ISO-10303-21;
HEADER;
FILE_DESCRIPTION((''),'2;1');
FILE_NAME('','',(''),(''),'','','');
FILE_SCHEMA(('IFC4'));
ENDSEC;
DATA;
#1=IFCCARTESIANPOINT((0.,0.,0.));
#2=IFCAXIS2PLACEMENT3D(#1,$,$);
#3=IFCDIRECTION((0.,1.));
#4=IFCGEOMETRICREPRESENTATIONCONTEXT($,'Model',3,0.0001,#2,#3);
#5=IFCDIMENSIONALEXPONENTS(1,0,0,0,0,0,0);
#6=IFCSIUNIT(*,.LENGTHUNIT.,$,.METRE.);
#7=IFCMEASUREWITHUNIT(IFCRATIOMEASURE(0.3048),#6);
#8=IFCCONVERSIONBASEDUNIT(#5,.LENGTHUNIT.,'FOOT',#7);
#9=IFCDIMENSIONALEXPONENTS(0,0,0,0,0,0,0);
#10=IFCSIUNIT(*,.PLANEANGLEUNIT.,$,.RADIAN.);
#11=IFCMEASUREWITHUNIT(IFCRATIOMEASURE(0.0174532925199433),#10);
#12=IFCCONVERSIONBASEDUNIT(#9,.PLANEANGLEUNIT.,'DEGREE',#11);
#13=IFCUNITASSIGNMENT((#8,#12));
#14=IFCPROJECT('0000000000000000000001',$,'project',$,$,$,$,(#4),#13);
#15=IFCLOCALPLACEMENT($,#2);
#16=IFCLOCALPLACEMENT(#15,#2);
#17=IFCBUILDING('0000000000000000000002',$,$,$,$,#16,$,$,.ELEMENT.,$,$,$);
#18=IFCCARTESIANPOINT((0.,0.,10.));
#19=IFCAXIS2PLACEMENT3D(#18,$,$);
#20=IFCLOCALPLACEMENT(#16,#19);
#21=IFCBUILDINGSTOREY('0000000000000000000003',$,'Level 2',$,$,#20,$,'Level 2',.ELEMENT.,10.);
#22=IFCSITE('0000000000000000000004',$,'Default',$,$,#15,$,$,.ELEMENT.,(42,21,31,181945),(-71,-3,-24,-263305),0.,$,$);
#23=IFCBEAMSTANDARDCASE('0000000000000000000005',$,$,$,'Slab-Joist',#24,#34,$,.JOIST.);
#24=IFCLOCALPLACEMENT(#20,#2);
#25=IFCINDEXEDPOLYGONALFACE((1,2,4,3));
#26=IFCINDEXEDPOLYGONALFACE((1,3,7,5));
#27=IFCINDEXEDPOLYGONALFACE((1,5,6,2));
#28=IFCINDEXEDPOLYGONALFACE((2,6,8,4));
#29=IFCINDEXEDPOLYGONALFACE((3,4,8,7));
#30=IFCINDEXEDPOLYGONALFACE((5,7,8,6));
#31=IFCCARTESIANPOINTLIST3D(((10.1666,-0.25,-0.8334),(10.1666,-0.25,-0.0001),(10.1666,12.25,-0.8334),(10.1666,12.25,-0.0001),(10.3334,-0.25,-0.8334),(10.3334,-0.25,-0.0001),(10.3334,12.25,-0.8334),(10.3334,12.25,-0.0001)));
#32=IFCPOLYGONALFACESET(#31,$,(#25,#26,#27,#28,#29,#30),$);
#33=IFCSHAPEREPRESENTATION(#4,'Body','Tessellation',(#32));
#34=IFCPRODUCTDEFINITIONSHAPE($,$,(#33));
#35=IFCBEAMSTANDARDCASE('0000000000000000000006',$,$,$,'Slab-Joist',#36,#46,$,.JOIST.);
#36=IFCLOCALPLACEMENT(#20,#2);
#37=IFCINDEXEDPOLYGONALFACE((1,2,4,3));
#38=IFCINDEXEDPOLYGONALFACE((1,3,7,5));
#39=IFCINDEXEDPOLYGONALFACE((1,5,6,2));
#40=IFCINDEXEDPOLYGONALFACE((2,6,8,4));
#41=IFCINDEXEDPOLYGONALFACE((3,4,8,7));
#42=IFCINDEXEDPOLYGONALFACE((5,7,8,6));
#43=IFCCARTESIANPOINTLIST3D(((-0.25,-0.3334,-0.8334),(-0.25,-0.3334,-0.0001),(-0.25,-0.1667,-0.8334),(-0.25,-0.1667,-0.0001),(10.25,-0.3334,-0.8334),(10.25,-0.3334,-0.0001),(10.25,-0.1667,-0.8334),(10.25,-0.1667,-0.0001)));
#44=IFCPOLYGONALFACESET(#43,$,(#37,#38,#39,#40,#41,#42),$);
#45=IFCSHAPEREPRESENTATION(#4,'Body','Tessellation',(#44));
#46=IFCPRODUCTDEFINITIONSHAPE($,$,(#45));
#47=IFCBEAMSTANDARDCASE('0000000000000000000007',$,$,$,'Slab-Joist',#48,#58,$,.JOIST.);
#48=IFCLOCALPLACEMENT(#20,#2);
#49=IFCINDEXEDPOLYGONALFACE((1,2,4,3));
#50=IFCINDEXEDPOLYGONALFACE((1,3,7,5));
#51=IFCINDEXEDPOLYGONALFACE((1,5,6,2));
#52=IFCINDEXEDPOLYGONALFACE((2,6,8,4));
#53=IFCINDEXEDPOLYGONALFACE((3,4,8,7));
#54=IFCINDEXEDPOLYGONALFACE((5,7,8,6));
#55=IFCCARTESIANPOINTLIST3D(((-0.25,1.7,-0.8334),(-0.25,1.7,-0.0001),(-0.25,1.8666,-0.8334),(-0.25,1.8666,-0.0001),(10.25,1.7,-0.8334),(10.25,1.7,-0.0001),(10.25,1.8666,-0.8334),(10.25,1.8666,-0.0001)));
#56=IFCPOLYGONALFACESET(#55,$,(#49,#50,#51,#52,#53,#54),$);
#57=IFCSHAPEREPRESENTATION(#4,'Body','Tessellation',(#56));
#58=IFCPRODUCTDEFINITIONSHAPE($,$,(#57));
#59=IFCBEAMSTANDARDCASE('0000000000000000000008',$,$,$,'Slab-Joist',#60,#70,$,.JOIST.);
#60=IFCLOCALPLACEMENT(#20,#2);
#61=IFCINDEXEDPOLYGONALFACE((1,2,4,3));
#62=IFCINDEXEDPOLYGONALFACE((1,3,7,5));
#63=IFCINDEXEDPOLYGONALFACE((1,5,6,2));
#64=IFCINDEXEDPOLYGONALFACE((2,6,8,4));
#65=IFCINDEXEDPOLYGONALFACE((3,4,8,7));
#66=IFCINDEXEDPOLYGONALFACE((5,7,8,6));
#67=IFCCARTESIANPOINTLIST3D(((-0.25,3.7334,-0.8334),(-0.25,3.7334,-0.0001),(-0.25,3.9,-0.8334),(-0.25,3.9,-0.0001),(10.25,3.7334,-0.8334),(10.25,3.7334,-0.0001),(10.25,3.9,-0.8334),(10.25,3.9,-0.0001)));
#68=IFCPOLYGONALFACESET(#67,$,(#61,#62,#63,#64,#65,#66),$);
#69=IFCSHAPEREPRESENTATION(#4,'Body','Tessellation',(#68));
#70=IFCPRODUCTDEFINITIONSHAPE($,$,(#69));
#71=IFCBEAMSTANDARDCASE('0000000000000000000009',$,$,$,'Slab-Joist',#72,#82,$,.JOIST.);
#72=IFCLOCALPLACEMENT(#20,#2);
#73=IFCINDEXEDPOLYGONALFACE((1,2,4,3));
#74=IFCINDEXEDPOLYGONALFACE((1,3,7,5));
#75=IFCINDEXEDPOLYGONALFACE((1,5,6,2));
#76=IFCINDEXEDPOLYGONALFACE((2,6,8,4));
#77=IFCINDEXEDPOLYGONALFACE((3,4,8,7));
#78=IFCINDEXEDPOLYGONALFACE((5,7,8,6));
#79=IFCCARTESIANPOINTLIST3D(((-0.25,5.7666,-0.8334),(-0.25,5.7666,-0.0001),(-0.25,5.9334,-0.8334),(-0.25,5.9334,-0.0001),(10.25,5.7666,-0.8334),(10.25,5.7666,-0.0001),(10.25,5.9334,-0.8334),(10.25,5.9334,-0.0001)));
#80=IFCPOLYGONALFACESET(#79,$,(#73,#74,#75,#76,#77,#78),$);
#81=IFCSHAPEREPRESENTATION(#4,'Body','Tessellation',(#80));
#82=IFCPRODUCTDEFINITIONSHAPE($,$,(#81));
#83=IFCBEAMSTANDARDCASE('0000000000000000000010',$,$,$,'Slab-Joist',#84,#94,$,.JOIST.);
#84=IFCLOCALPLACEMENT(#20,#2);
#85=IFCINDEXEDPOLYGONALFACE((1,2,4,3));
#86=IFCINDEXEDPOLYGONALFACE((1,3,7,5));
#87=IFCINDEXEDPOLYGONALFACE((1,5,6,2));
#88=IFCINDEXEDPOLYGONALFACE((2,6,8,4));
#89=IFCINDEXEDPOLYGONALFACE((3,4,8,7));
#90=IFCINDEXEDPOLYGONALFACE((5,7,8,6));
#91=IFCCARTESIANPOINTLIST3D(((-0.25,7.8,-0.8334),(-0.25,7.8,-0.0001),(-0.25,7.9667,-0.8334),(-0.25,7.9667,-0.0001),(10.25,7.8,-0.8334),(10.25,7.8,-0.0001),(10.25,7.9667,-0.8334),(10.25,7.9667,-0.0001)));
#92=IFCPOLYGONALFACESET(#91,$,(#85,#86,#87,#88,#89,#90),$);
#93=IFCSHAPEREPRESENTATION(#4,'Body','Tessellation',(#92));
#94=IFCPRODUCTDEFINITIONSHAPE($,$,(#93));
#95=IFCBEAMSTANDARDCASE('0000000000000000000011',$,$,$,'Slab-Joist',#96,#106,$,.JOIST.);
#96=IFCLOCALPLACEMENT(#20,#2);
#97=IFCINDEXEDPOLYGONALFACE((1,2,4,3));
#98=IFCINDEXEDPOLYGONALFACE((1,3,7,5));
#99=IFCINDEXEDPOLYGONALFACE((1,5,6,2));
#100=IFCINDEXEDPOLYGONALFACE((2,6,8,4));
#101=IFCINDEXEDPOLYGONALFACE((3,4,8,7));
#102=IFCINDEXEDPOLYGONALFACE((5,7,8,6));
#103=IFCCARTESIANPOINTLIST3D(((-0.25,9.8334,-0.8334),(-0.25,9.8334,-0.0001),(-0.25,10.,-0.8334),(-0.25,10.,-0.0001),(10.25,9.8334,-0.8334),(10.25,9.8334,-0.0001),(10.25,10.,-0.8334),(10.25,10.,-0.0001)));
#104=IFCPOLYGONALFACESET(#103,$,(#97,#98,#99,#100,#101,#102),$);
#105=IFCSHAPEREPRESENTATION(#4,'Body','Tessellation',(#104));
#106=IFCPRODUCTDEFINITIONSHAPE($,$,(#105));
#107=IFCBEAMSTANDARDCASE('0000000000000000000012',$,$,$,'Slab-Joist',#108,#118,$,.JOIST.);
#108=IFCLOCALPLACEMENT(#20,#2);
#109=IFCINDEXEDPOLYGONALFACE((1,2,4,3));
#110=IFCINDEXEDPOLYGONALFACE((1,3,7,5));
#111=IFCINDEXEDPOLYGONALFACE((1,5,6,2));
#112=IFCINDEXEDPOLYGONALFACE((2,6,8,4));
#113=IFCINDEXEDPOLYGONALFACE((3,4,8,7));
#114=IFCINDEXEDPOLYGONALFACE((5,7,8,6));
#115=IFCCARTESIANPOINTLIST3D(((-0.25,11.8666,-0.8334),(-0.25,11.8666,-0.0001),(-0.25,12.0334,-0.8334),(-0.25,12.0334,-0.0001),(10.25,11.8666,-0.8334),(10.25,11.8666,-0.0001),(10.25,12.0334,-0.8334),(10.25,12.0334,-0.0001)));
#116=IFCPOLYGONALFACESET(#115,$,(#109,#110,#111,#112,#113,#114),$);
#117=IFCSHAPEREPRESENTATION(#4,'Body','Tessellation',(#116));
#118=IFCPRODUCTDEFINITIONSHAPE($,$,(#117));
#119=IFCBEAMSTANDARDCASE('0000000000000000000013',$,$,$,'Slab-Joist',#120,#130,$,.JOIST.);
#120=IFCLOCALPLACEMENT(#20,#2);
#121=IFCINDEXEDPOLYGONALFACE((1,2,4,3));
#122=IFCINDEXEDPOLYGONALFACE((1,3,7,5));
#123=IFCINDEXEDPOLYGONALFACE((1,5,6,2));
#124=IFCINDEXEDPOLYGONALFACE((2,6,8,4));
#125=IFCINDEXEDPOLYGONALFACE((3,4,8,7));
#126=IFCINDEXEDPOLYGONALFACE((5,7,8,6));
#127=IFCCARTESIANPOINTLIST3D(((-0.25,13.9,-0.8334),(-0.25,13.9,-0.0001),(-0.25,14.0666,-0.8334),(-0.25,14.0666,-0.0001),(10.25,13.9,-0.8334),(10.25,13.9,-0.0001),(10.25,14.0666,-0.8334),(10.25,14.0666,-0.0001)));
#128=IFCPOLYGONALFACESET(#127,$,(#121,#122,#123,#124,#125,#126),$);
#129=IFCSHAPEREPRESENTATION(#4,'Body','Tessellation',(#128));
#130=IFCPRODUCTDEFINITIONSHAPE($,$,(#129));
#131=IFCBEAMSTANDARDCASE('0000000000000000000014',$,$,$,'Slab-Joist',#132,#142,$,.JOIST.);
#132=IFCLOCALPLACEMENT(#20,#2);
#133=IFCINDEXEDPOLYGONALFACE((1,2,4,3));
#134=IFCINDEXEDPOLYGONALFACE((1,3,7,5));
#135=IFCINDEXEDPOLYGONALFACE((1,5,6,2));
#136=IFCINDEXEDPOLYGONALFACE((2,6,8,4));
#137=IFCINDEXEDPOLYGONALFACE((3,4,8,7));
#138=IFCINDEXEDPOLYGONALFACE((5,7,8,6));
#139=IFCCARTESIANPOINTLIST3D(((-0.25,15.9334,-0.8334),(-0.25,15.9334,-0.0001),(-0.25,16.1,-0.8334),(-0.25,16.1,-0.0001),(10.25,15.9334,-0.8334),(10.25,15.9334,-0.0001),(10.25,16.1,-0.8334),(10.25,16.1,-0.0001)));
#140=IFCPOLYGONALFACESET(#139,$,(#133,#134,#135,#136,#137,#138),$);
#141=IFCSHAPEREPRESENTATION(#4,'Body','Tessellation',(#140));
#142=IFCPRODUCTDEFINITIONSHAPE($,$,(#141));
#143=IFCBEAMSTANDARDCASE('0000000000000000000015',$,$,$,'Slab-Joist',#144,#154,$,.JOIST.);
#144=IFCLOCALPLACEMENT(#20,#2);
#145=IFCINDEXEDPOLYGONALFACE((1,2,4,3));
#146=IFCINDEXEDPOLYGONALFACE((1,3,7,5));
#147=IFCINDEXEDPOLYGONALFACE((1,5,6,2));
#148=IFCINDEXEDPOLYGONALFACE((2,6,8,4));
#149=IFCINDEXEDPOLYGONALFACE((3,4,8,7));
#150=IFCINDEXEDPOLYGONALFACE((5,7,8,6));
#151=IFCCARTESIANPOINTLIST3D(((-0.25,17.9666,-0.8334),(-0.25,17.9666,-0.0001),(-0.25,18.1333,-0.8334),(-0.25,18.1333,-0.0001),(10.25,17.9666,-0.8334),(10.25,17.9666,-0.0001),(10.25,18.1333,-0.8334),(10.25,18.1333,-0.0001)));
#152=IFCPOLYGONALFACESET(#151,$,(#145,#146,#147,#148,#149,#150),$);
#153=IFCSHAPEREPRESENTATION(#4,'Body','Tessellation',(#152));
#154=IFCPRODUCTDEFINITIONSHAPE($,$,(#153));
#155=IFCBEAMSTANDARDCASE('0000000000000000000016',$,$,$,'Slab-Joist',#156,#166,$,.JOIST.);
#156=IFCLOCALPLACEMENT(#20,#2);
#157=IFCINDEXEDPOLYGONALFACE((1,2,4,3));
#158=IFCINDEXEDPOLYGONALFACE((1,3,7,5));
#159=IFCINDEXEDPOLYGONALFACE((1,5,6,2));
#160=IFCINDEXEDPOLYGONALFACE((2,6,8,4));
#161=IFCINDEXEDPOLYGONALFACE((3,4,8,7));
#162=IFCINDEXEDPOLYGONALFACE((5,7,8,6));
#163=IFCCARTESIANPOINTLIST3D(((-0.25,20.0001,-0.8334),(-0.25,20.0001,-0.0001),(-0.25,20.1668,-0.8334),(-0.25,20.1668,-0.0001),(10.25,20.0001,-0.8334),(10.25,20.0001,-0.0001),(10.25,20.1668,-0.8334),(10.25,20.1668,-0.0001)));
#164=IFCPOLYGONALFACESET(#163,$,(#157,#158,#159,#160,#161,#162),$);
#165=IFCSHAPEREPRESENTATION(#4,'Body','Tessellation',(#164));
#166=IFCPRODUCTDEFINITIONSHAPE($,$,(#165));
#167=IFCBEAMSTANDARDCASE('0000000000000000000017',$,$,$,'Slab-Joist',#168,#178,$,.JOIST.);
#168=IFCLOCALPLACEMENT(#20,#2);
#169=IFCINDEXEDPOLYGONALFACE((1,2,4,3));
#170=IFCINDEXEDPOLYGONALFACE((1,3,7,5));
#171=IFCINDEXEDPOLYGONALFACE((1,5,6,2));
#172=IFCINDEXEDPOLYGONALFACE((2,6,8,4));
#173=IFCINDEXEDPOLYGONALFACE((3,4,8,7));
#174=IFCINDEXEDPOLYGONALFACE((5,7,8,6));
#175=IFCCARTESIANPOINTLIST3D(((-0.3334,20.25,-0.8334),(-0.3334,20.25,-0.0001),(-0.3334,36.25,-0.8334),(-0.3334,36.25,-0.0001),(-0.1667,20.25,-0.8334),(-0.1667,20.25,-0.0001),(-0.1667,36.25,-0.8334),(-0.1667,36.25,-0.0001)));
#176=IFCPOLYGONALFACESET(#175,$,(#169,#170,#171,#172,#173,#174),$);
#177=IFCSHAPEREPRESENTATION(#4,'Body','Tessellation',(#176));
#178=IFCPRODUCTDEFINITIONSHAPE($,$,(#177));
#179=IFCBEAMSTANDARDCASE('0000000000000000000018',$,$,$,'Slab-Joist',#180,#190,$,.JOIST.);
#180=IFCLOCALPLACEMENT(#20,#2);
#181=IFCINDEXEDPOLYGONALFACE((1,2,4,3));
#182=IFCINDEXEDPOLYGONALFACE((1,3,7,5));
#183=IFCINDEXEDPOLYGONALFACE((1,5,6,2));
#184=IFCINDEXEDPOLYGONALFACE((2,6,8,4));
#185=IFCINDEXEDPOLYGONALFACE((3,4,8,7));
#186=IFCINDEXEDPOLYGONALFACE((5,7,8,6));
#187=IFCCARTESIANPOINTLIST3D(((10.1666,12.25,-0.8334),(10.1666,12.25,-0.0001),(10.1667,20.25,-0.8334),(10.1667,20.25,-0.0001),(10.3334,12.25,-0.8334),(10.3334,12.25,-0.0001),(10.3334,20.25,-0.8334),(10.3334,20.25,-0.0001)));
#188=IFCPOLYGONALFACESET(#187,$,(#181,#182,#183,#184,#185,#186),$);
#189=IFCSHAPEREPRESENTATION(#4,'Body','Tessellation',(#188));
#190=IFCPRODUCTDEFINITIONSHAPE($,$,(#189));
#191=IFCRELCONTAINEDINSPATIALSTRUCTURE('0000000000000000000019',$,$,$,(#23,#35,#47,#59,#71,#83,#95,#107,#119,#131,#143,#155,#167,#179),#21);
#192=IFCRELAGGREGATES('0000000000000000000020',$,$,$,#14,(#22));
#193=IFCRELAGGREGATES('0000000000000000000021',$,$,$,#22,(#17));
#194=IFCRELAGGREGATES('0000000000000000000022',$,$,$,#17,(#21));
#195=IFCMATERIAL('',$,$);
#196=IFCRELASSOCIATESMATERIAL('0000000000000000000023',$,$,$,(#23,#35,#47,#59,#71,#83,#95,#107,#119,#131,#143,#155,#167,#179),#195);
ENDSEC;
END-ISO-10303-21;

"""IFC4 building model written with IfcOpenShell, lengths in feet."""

from ifc_helpers import new_model, entity, si_unit, converted_unit, direction, frame, origin, origin_with_axes, place, context, project, spatial, rectangle, extrude, material, element, save


model = new_model("IFC4")

# Units and contexts
model_context = context("Model", 3, precision=0.0001, world=origin(), true_north=direction((0.0, 1.0)))
ifc_project = project(units=[converted_unit("LENGTHUNIT", "FOOT", entity("IfcRatioMeasure", 0.3048), si_unit("LENGTHUNIT", "METRE"), dimensions=[1, 0, 0, 0, 0, 0, 0]), converted_unit("PLANEANGLEUNIT", "DEGREE", entity("IfcRatioMeasure", 0.0174532925199433), si_unit("PLANEANGLEUNIT", "RADIAN"), dimensions=[0, 0, 0, 0, 0, 0, 0])], contexts=[model_context])

# Site, building, storey
site_placement = place(None, origin())
site = spatial("IfcSite", under=ifc_project, at=site_placement, Name="Default", CompositionType="ELEMENT", RefLatitude=(42, 21, 31, 181945), RefLongitude=(-71, -3, -24, -263305), RefElevation=0.0)
building_placement = place(site_placement, origin())
building = spatial("IfcBuilding", under=site, at=building_placement, CompositionType="ELEMENT")
storey_placement = place(building_placement, frame((0.0, 0.0, 10.0)))
storey = spatial("IfcBuildingStorey", under=building, at=storey_placement, Name="Level 2", LongName="Level 2", CompositionType="ELEMENT", Elevation=10.0)

# Beams
ifc_material = material(Name="")
placement_1 = place(storey_placement, frame((10.25, -0.25, 0.0), z_axis=(0.0, 0.0, 1.0), x_axis=(1.0, 0.0, 0.0)))
beam_1_placement = place(placement_1, frame((0.0, 0.0, -0.4167), z_axis=(0.0, 1.0, 0.0), x_axis=(-1.0, 0.0, 0.0)))
element("IfcBeamStandardCase", 1, at=beam_1_placement, inside=storey, material=ifc_material, ObjectType="Slab-Joist", PredefinedType="JOIST", context=model_context, shape_type="SweptSolid", body=[
    extrude(rectangle(XDim=0.1667, YDim=0.8333), origin_with_axes(), (0.0, 0.0, 1.0), 12.5),
])
placement_2 = place(storey_placement, frame((-0.25, -0.25, 0.0), z_axis=(0.0, 0.0, 1.0), x_axis=(1.0, 0.0, 0.0)))
beam_2_placement = place(placement_2, frame((0.0, 0.0, -0.4167), z_axis=(1.0, 0.0, 0.0), x_axis=(0.0, 1.0, 0.0)))
element("IfcBeamStandardCase", 2, at=beam_2_placement, inside=storey, material=ifc_material, ObjectType="Slab-Joist", PredefinedType="JOIST", context=model_context, shape_type="SweptSolid", body=[
    extrude(rectangle(XDim=0.1667, YDim=0.8333), origin_with_axes(), (0.0, 0.0, 1.0), 10.5),
])
placement_3 = place(storey_placement, frame((-0.25, -0.25, 0.0), z_axis=(0.0, 0.0, 1.0), x_axis=(1.0, 0.0, 0.0)))
beam_3_placement = place(placement_3, frame((0.0, 2.0333, -0.4167), z_axis=(1.0, 0.0, 0.0), x_axis=(0.0, 1.0, 0.0)))
element("IfcBeamStandardCase", 3, at=beam_3_placement, inside=storey, material=ifc_material, ObjectType="Slab-Joist", PredefinedType="JOIST", context=model_context, shape_type="SweptSolid", body=[
    extrude(rectangle(XDim=0.1667, YDim=0.8333), origin_with_axes(), (0.0, 0.0, 1.0), 10.5),
])
placement_4 = place(storey_placement, frame((-0.25, -0.25, 0.0), z_axis=(0.0, 0.0, 1.0), x_axis=(1.0, 0.0, 0.0)))
beam_4_placement = place(placement_4, frame((0.0, 4.0667, -0.4167), z_axis=(1.0, 0.0, 0.0), x_axis=(0.0, 1.0, 0.0)))
element("IfcBeamStandardCase", 4, at=beam_4_placement, inside=storey, material=ifc_material, ObjectType="Slab-Joist", PredefinedType="JOIST", context=model_context, shape_type="SweptSolid", body=[
    extrude(rectangle(XDim=0.1667, YDim=0.8333), origin_with_axes(), (0.0, 0.0, 1.0), 10.5),
])
placement_5 = place(storey_placement, frame((-0.25, -0.25, 0.0), z_axis=(0.0, 0.0, 1.0), x_axis=(1.0, 0.0, 0.0)))
beam_5_placement = place(placement_5, frame((0.0, 6.1, -0.4167), z_axis=(1.0, 0.0, 0.0), x_axis=(0.0, 1.0, 0.0)))
element("IfcBeamStandardCase", 5, at=beam_5_placement, inside=storey, material=ifc_material, ObjectType="Slab-Joist", PredefinedType="JOIST", context=model_context, shape_type="SweptSolid", body=[
    extrude(rectangle(XDim=0.1667, YDim=0.8333), origin_with_axes(), (0.0, 0.0, 1.0), 10.5),
])
placement_6 = place(storey_placement, frame((-0.25, -0.25, 0.0), z_axis=(0.0, 0.0, 1.0), x_axis=(1.0, 0.0, 0.0)))
beam_6_placement = place(placement_6, frame((0.0, 8.1333, -0.4167), z_axis=(1.0, 0.0, 0.0), x_axis=(0.0, 1.0, 0.0)))
element("IfcBeamStandardCase", 6, at=beam_6_placement, inside=storey, material=ifc_material, ObjectType="Slab-Joist", PredefinedType="JOIST", context=model_context, shape_type="SweptSolid", body=[
    extrude(rectangle(XDim=0.1667, YDim=0.8333), origin_with_axes(), (0.0, 0.0, 1.0), 10.5),
])
placement_7 = place(storey_placement, frame((-0.25, -0.25, 0.0), z_axis=(0.0, 0.0, 1.0), x_axis=(1.0, 0.0, 0.0)))
beam_7_placement = place(placement_7, frame((0.0, 10.1667, -0.4167), z_axis=(1.0, 0.0, 0.0), x_axis=(0.0, 1.0, 0.0)))
element("IfcBeamStandardCase", 7, at=beam_7_placement, inside=storey, material=ifc_material, ObjectType="Slab-Joist", PredefinedType="JOIST", context=model_context, shape_type="SweptSolid", body=[
    extrude(rectangle(XDim=0.1667, YDim=0.8333), origin_with_axes(), (0.0, 0.0, 1.0), 10.5),
])
placement_8 = place(storey_placement, frame((-0.25, -0.25, 0.0), z_axis=(0.0, 0.0, 1.0), x_axis=(1.0, 0.0, 0.0)))
beam_8_placement = place(placement_8, frame((0.0, 12.2, -0.4167), z_axis=(1.0, 0.0, 0.0), x_axis=(0.0, 1.0, 0.0)))
element("IfcBeamStandardCase", 8, at=beam_8_placement, inside=storey, material=ifc_material, ObjectType="Slab-Joist", PredefinedType="JOIST", context=model_context, shape_type="SweptSolid", body=[
    extrude(rectangle(XDim=0.1667, YDim=0.8333), origin_with_axes(), (0.0, 0.0, 1.0), 10.5),
])
placement_9 = place(storey_placement, frame((-0.25, -0.25, 0.0), z_axis=(0.0, 0.0, 1.0), x_axis=(1.0, 0.0, 0.0)))
beam_9_placement = place(placement_9, frame((0.0, 14.2333, -0.4167), z_axis=(1.0, 0.0, 0.0), x_axis=(0.0, 1.0, 0.0)))
element("IfcBeamStandardCase", 9, at=beam_9_placement, inside=storey, material=ifc_material, ObjectType="Slab-Joist", PredefinedType="JOIST", context=model_context, shape_type="SweptSolid", body=[
    extrude(rectangle(XDim=0.1667, YDim=0.8333), origin_with_axes(), (0.0, 0.0, 1.0), 10.5),
])
placement_10 = place(storey_placement, frame((-0.25, -0.25, 0.0), z_axis=(0.0, 0.0, 1.0), x_axis=(1.0, 0.0, 0.0)))
beam_10_placement = place(placement_10, frame((0.0, 16.2667, -0.4167), z_axis=(1.0, 0.0, 0.0), x_axis=(0.0, 1.0, 0.0)))
element("IfcBeamStandardCase", 10, at=beam_10_placement, inside=storey, material=ifc_material, ObjectType="Slab-Joist", PredefinedType="JOIST", context=model_context, shape_type="SweptSolid", body=[
    extrude(rectangle(XDim=0.1667, YDim=0.8333), origin_with_axes(), (0.0, 0.0, 1.0), 10.5),
])
placement_11 = place(storey_placement, frame((-0.25, -0.25, 0.0), z_axis=(0.0, 0.0, 1.0), x_axis=(1.0, 0.0, 0.0)))
beam_11_placement = place(placement_11, frame((0.0, 18.3, -0.4167), z_axis=(1.0, 0.0, 0.0), x_axis=(0.0, 1.0, 0.0)))
element("IfcBeamStandardCase", 11, at=beam_11_placement, inside=storey, material=ifc_material, ObjectType="Slab-Joist", PredefinedType="JOIST", context=model_context, shape_type="SweptSolid", body=[
    extrude(rectangle(XDim=0.1667, YDim=0.8333), origin_with_axes(), (0.0, 0.0, 1.0), 10.5),
])
placement_12 = place(storey_placement, frame((-0.25, -0.25, 0.0), z_axis=(0.0, 0.0, 1.0), x_axis=(1.0, 0.0, 0.0)))
beam_12_placement = place(placement_12, frame((0.0, 20.3334, -0.4167), z_axis=(1.0, 0.0, 0.0), x_axis=(0.0, 1.0, 0.0)))
element("IfcBeamStandardCase", 12, at=beam_12_placement, inside=storey, material=ifc_material, ObjectType="Slab-Joist", PredefinedType="JOIST", context=model_context, shape_type="SweptSolid", body=[
    extrude(rectangle(XDim=0.1667, YDim=0.8333), origin_with_axes(), (0.0, 0.0, 1.0), 10.5),
])
placement_13 = place(storey_placement, frame((-0.25, 20.25, 0.0), z_axis=(0.0, 0.0, 1.0), x_axis=(1.0, 0.0, 0.0)))
beam_13_placement = place(placement_13, frame((0.0, 0.0, -0.4167), z_axis=(0.0, 1.0, 0.0), x_axis=(-1.0, 0.0, 0.0)))
element("IfcBeamStandardCase", 13, at=beam_13_placement, inside=storey, material=ifc_material, ObjectType="Slab-Joist", PredefinedType="JOIST", context=model_context, shape_type="SweptSolid", body=[
    extrude(rectangle(XDim=0.1667, YDim=0.8333), origin_with_axes(), (0.0, 0.0, 1.0), 16.0),
])
placement_14 = place(storey_placement, frame((10.25, 12.25, 0.0), z_axis=(0.0, 0.0, 1.0), x_axis=(1.0, 0.0, 0.0)))
beam_14_placement = place(placement_14, frame((0.0, 0.0, -0.4167), z_axis=(0.0, 1.0, 0.0), x_axis=(-1.0, 0.0, 0.0)))
element("IfcBeamStandardCase", 14, at=beam_14_placement, inside=storey, material=ifc_material, ObjectType="Slab-Joist", PredefinedType="JOIST", context=model_context, shape_type="SweptSolid", body=[
    extrude(rectangle(XDim=0.1667, YDim=0.8333), origin_with_axes(), (0.0, 0.0, 1.0), 8.0),
])

save(model, "model.ifc")
